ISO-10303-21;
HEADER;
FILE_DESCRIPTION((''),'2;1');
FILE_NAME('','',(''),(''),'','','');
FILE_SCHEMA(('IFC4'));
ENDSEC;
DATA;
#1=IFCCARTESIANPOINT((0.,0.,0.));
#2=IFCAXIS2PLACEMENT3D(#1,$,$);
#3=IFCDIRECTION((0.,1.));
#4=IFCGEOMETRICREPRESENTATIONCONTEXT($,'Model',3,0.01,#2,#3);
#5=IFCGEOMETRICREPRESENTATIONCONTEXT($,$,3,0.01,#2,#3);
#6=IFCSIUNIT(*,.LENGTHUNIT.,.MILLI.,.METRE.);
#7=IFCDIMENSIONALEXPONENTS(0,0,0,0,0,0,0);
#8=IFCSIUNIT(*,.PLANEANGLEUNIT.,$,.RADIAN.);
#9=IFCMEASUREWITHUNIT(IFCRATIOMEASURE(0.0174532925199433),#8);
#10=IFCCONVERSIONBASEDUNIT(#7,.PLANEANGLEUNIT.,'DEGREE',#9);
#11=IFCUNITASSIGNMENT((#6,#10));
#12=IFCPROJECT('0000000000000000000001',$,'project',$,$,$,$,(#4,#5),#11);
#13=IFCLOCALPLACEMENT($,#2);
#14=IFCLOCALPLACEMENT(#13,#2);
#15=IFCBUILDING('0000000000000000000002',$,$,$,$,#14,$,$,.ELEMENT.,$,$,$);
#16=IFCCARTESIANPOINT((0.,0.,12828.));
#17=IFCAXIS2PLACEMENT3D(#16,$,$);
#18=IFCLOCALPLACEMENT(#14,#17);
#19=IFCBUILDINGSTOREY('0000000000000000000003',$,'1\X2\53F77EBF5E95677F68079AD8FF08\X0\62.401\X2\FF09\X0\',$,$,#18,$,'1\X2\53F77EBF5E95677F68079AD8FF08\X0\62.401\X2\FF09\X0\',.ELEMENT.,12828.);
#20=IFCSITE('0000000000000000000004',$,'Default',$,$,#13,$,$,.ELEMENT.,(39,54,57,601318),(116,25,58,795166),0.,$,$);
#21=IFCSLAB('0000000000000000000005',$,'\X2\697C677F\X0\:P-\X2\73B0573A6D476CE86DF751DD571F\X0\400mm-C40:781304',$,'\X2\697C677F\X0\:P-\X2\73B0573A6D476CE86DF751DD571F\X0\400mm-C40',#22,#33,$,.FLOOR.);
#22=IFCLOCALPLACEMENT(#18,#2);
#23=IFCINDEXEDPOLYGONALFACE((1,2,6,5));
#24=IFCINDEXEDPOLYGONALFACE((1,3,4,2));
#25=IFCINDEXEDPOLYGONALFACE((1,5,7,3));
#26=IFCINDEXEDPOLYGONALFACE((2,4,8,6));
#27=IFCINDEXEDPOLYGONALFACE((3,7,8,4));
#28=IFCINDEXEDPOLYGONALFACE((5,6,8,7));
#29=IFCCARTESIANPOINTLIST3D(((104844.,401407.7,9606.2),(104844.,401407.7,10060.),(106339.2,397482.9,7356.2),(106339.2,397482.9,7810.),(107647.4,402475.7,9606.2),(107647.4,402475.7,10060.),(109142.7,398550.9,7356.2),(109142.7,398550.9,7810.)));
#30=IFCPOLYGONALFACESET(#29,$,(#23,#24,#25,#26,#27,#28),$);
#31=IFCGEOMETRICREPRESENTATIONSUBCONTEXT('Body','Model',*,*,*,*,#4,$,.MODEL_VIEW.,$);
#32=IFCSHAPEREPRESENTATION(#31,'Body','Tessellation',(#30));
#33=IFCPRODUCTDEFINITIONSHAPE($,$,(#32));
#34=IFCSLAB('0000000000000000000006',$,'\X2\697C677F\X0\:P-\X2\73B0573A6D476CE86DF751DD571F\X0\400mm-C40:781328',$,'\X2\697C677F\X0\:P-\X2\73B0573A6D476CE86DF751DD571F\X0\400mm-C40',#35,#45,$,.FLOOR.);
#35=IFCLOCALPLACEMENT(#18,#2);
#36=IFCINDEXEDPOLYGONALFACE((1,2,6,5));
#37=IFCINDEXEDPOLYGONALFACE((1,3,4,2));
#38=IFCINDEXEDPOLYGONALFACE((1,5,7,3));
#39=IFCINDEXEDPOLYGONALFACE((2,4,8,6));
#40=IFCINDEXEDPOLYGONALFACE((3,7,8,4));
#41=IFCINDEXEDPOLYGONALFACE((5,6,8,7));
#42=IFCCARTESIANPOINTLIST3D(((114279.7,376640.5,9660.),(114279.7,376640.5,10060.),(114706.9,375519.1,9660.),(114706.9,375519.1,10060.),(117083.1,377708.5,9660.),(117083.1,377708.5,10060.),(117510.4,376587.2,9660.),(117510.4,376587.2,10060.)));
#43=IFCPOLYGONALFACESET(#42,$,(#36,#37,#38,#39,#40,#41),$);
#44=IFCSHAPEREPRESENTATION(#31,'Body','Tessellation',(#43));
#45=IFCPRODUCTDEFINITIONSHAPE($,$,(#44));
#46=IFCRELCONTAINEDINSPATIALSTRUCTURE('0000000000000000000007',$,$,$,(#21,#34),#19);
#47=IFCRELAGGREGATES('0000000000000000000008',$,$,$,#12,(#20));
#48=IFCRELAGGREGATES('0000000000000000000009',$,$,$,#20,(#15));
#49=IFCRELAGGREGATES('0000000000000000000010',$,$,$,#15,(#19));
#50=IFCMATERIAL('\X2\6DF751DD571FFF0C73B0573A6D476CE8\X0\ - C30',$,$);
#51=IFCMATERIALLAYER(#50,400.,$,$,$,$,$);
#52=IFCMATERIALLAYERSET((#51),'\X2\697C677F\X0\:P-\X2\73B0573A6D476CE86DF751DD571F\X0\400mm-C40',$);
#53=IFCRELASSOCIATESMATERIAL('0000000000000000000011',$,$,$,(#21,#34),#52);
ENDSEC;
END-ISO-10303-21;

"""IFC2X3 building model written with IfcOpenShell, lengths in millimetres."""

from ifc_helpers import new_model, entity, si_unit, converted_unit, direction, frame, frame_2d, origin, place, context, subcontext, project, spatial, rectangle, extrude, clip, halfspace, material, layer, layer_set, layer_usage, element, save


model = new_model("IFC2X3")

# Units and contexts
model_context = context("Model", 3, precision=0.01, world=origin(), true_north=direction((0.0, 1.0)))
context_of_model = context(None, 3, precision=0.01, world=origin(), true_north=direction((0.0, 1.0)))
body_context = subcontext(model_context, "Body", "Model", "MODEL_VIEW")
ifc_project = project(units=[si_unit("LENGTHUNIT", "METRE", prefix="MILLI"), converted_unit("PLANEANGLEUNIT", "DEGREE", entity("IfcRatioMeasure", 0.0174532925199433), si_unit("PLANEANGLEUNIT", "RADIAN"), dimensions=[0, 0, 0, 0, 0, 0, 0])], contexts=[model_context, context_of_model])

# Site, building, storey
site_placement = place(None, origin())
site = spatial("IfcSite", under=ifc_project, at=site_placement, Name="Default", CompositionType="ELEMENT", RefLatitude=(39, 54, 57, 601318), RefLongitude=(116, 25, 58, 795166), RefElevation=0.0)
building_placement = place(site_placement, origin())
building = spatial("IfcBuilding", under=site, at=building_placement, CompositionType="ELEMENT")
storey_placement = place(building_placement, frame((0.0, 0.0, 12828.0)))
storey = spatial("IfcBuildingStorey", under=building, at=storey_placement, Name="1号线底板标高（62.401）", LongName="1号线底板标高（62.401）", CompositionType="ELEMENT", Elevation=12828.0)

# Slabs
ifc_material = material(Name="混凝土，现场浇注 - C30")
ifc_layer = layer(ifc_material, 400.0)
ifc_layer_set = layer_set([ifc_layer], Name="楼板:P-现场浇注混凝土400mm-C40")
ifc_layer_usage_1 = layer_usage(ifc_layer_set, "AXIS3", "POSITIVE", 0.0)
slab_1_placement = place(storey_placement, origin())
element("IfcSlab", 1, at=slab_1_placement, inside=storey, material=ifc_layer_usage_1, Name="楼板:P-现场浇注混凝土400mm-C40:781304", ObjectType="楼板:P-现场浇注混凝土400mm-C40", PredefinedType="FLOOR", context=body_context, shape_type="Clipping", body=[
    clip(clip(extrude(rectangle(XDim=4764.7, YDim=3000.0, at=frame_2d((0.0, 0.0), x_axis=(1.0, 0.0))), frame((106993.3, 399979.3, 8935.0), z_axis=(-0.168119, 0.441281, -0.88148), x_axis=(0.313822, -0.823725, -0.472221)), (0.472221, 0.0, 0.88148), 514.8), halfspace(frame((106245.7, 401941.7, 10060.0), z_axis=(0.168119, -0.441281, 0.88148), x_axis=(0.985767, 0.075259, -0.150333)), False)), halfspace(frame((106245.7, 401941.7, 9606.2), z_axis=(-0.168119, 0.441281, -0.88148), x_axis=(0.985767, 0.075259, -0.150333)), False)),
])
ifc_layer_usage_2 = layer_usage(ifc_layer_set, "AXIS3", "POSITIVE", 0.0)
slab_2_placement = place(storey_placement, origin())
element("IfcSlab", 2, at=slab_2_placement, inside=storey, material=ifc_layer_usage_2, Name="楼板:P-现场浇注混凝土400mm-C40:781328", ObjectType="楼板:P-现场浇注混凝土400mm-C40", PredefinedType="FLOOR", context=body_context, shape_type="SweptSolid", body=[
    extrude(rectangle(XDim=3000.0, YDim=1200.0, at=frame_2d((0.0, 0.0), x_axis=(1.0, 0.0))), frame((115895.0, 376613.8, 10060.0), z_axis=(0.0, 0.0, -1.0), x_axis=(0.934481, 0.356012, 0.0)), (0.0, 0.0, 1.0), 400.0),
])

save(model, "model.ifc")
